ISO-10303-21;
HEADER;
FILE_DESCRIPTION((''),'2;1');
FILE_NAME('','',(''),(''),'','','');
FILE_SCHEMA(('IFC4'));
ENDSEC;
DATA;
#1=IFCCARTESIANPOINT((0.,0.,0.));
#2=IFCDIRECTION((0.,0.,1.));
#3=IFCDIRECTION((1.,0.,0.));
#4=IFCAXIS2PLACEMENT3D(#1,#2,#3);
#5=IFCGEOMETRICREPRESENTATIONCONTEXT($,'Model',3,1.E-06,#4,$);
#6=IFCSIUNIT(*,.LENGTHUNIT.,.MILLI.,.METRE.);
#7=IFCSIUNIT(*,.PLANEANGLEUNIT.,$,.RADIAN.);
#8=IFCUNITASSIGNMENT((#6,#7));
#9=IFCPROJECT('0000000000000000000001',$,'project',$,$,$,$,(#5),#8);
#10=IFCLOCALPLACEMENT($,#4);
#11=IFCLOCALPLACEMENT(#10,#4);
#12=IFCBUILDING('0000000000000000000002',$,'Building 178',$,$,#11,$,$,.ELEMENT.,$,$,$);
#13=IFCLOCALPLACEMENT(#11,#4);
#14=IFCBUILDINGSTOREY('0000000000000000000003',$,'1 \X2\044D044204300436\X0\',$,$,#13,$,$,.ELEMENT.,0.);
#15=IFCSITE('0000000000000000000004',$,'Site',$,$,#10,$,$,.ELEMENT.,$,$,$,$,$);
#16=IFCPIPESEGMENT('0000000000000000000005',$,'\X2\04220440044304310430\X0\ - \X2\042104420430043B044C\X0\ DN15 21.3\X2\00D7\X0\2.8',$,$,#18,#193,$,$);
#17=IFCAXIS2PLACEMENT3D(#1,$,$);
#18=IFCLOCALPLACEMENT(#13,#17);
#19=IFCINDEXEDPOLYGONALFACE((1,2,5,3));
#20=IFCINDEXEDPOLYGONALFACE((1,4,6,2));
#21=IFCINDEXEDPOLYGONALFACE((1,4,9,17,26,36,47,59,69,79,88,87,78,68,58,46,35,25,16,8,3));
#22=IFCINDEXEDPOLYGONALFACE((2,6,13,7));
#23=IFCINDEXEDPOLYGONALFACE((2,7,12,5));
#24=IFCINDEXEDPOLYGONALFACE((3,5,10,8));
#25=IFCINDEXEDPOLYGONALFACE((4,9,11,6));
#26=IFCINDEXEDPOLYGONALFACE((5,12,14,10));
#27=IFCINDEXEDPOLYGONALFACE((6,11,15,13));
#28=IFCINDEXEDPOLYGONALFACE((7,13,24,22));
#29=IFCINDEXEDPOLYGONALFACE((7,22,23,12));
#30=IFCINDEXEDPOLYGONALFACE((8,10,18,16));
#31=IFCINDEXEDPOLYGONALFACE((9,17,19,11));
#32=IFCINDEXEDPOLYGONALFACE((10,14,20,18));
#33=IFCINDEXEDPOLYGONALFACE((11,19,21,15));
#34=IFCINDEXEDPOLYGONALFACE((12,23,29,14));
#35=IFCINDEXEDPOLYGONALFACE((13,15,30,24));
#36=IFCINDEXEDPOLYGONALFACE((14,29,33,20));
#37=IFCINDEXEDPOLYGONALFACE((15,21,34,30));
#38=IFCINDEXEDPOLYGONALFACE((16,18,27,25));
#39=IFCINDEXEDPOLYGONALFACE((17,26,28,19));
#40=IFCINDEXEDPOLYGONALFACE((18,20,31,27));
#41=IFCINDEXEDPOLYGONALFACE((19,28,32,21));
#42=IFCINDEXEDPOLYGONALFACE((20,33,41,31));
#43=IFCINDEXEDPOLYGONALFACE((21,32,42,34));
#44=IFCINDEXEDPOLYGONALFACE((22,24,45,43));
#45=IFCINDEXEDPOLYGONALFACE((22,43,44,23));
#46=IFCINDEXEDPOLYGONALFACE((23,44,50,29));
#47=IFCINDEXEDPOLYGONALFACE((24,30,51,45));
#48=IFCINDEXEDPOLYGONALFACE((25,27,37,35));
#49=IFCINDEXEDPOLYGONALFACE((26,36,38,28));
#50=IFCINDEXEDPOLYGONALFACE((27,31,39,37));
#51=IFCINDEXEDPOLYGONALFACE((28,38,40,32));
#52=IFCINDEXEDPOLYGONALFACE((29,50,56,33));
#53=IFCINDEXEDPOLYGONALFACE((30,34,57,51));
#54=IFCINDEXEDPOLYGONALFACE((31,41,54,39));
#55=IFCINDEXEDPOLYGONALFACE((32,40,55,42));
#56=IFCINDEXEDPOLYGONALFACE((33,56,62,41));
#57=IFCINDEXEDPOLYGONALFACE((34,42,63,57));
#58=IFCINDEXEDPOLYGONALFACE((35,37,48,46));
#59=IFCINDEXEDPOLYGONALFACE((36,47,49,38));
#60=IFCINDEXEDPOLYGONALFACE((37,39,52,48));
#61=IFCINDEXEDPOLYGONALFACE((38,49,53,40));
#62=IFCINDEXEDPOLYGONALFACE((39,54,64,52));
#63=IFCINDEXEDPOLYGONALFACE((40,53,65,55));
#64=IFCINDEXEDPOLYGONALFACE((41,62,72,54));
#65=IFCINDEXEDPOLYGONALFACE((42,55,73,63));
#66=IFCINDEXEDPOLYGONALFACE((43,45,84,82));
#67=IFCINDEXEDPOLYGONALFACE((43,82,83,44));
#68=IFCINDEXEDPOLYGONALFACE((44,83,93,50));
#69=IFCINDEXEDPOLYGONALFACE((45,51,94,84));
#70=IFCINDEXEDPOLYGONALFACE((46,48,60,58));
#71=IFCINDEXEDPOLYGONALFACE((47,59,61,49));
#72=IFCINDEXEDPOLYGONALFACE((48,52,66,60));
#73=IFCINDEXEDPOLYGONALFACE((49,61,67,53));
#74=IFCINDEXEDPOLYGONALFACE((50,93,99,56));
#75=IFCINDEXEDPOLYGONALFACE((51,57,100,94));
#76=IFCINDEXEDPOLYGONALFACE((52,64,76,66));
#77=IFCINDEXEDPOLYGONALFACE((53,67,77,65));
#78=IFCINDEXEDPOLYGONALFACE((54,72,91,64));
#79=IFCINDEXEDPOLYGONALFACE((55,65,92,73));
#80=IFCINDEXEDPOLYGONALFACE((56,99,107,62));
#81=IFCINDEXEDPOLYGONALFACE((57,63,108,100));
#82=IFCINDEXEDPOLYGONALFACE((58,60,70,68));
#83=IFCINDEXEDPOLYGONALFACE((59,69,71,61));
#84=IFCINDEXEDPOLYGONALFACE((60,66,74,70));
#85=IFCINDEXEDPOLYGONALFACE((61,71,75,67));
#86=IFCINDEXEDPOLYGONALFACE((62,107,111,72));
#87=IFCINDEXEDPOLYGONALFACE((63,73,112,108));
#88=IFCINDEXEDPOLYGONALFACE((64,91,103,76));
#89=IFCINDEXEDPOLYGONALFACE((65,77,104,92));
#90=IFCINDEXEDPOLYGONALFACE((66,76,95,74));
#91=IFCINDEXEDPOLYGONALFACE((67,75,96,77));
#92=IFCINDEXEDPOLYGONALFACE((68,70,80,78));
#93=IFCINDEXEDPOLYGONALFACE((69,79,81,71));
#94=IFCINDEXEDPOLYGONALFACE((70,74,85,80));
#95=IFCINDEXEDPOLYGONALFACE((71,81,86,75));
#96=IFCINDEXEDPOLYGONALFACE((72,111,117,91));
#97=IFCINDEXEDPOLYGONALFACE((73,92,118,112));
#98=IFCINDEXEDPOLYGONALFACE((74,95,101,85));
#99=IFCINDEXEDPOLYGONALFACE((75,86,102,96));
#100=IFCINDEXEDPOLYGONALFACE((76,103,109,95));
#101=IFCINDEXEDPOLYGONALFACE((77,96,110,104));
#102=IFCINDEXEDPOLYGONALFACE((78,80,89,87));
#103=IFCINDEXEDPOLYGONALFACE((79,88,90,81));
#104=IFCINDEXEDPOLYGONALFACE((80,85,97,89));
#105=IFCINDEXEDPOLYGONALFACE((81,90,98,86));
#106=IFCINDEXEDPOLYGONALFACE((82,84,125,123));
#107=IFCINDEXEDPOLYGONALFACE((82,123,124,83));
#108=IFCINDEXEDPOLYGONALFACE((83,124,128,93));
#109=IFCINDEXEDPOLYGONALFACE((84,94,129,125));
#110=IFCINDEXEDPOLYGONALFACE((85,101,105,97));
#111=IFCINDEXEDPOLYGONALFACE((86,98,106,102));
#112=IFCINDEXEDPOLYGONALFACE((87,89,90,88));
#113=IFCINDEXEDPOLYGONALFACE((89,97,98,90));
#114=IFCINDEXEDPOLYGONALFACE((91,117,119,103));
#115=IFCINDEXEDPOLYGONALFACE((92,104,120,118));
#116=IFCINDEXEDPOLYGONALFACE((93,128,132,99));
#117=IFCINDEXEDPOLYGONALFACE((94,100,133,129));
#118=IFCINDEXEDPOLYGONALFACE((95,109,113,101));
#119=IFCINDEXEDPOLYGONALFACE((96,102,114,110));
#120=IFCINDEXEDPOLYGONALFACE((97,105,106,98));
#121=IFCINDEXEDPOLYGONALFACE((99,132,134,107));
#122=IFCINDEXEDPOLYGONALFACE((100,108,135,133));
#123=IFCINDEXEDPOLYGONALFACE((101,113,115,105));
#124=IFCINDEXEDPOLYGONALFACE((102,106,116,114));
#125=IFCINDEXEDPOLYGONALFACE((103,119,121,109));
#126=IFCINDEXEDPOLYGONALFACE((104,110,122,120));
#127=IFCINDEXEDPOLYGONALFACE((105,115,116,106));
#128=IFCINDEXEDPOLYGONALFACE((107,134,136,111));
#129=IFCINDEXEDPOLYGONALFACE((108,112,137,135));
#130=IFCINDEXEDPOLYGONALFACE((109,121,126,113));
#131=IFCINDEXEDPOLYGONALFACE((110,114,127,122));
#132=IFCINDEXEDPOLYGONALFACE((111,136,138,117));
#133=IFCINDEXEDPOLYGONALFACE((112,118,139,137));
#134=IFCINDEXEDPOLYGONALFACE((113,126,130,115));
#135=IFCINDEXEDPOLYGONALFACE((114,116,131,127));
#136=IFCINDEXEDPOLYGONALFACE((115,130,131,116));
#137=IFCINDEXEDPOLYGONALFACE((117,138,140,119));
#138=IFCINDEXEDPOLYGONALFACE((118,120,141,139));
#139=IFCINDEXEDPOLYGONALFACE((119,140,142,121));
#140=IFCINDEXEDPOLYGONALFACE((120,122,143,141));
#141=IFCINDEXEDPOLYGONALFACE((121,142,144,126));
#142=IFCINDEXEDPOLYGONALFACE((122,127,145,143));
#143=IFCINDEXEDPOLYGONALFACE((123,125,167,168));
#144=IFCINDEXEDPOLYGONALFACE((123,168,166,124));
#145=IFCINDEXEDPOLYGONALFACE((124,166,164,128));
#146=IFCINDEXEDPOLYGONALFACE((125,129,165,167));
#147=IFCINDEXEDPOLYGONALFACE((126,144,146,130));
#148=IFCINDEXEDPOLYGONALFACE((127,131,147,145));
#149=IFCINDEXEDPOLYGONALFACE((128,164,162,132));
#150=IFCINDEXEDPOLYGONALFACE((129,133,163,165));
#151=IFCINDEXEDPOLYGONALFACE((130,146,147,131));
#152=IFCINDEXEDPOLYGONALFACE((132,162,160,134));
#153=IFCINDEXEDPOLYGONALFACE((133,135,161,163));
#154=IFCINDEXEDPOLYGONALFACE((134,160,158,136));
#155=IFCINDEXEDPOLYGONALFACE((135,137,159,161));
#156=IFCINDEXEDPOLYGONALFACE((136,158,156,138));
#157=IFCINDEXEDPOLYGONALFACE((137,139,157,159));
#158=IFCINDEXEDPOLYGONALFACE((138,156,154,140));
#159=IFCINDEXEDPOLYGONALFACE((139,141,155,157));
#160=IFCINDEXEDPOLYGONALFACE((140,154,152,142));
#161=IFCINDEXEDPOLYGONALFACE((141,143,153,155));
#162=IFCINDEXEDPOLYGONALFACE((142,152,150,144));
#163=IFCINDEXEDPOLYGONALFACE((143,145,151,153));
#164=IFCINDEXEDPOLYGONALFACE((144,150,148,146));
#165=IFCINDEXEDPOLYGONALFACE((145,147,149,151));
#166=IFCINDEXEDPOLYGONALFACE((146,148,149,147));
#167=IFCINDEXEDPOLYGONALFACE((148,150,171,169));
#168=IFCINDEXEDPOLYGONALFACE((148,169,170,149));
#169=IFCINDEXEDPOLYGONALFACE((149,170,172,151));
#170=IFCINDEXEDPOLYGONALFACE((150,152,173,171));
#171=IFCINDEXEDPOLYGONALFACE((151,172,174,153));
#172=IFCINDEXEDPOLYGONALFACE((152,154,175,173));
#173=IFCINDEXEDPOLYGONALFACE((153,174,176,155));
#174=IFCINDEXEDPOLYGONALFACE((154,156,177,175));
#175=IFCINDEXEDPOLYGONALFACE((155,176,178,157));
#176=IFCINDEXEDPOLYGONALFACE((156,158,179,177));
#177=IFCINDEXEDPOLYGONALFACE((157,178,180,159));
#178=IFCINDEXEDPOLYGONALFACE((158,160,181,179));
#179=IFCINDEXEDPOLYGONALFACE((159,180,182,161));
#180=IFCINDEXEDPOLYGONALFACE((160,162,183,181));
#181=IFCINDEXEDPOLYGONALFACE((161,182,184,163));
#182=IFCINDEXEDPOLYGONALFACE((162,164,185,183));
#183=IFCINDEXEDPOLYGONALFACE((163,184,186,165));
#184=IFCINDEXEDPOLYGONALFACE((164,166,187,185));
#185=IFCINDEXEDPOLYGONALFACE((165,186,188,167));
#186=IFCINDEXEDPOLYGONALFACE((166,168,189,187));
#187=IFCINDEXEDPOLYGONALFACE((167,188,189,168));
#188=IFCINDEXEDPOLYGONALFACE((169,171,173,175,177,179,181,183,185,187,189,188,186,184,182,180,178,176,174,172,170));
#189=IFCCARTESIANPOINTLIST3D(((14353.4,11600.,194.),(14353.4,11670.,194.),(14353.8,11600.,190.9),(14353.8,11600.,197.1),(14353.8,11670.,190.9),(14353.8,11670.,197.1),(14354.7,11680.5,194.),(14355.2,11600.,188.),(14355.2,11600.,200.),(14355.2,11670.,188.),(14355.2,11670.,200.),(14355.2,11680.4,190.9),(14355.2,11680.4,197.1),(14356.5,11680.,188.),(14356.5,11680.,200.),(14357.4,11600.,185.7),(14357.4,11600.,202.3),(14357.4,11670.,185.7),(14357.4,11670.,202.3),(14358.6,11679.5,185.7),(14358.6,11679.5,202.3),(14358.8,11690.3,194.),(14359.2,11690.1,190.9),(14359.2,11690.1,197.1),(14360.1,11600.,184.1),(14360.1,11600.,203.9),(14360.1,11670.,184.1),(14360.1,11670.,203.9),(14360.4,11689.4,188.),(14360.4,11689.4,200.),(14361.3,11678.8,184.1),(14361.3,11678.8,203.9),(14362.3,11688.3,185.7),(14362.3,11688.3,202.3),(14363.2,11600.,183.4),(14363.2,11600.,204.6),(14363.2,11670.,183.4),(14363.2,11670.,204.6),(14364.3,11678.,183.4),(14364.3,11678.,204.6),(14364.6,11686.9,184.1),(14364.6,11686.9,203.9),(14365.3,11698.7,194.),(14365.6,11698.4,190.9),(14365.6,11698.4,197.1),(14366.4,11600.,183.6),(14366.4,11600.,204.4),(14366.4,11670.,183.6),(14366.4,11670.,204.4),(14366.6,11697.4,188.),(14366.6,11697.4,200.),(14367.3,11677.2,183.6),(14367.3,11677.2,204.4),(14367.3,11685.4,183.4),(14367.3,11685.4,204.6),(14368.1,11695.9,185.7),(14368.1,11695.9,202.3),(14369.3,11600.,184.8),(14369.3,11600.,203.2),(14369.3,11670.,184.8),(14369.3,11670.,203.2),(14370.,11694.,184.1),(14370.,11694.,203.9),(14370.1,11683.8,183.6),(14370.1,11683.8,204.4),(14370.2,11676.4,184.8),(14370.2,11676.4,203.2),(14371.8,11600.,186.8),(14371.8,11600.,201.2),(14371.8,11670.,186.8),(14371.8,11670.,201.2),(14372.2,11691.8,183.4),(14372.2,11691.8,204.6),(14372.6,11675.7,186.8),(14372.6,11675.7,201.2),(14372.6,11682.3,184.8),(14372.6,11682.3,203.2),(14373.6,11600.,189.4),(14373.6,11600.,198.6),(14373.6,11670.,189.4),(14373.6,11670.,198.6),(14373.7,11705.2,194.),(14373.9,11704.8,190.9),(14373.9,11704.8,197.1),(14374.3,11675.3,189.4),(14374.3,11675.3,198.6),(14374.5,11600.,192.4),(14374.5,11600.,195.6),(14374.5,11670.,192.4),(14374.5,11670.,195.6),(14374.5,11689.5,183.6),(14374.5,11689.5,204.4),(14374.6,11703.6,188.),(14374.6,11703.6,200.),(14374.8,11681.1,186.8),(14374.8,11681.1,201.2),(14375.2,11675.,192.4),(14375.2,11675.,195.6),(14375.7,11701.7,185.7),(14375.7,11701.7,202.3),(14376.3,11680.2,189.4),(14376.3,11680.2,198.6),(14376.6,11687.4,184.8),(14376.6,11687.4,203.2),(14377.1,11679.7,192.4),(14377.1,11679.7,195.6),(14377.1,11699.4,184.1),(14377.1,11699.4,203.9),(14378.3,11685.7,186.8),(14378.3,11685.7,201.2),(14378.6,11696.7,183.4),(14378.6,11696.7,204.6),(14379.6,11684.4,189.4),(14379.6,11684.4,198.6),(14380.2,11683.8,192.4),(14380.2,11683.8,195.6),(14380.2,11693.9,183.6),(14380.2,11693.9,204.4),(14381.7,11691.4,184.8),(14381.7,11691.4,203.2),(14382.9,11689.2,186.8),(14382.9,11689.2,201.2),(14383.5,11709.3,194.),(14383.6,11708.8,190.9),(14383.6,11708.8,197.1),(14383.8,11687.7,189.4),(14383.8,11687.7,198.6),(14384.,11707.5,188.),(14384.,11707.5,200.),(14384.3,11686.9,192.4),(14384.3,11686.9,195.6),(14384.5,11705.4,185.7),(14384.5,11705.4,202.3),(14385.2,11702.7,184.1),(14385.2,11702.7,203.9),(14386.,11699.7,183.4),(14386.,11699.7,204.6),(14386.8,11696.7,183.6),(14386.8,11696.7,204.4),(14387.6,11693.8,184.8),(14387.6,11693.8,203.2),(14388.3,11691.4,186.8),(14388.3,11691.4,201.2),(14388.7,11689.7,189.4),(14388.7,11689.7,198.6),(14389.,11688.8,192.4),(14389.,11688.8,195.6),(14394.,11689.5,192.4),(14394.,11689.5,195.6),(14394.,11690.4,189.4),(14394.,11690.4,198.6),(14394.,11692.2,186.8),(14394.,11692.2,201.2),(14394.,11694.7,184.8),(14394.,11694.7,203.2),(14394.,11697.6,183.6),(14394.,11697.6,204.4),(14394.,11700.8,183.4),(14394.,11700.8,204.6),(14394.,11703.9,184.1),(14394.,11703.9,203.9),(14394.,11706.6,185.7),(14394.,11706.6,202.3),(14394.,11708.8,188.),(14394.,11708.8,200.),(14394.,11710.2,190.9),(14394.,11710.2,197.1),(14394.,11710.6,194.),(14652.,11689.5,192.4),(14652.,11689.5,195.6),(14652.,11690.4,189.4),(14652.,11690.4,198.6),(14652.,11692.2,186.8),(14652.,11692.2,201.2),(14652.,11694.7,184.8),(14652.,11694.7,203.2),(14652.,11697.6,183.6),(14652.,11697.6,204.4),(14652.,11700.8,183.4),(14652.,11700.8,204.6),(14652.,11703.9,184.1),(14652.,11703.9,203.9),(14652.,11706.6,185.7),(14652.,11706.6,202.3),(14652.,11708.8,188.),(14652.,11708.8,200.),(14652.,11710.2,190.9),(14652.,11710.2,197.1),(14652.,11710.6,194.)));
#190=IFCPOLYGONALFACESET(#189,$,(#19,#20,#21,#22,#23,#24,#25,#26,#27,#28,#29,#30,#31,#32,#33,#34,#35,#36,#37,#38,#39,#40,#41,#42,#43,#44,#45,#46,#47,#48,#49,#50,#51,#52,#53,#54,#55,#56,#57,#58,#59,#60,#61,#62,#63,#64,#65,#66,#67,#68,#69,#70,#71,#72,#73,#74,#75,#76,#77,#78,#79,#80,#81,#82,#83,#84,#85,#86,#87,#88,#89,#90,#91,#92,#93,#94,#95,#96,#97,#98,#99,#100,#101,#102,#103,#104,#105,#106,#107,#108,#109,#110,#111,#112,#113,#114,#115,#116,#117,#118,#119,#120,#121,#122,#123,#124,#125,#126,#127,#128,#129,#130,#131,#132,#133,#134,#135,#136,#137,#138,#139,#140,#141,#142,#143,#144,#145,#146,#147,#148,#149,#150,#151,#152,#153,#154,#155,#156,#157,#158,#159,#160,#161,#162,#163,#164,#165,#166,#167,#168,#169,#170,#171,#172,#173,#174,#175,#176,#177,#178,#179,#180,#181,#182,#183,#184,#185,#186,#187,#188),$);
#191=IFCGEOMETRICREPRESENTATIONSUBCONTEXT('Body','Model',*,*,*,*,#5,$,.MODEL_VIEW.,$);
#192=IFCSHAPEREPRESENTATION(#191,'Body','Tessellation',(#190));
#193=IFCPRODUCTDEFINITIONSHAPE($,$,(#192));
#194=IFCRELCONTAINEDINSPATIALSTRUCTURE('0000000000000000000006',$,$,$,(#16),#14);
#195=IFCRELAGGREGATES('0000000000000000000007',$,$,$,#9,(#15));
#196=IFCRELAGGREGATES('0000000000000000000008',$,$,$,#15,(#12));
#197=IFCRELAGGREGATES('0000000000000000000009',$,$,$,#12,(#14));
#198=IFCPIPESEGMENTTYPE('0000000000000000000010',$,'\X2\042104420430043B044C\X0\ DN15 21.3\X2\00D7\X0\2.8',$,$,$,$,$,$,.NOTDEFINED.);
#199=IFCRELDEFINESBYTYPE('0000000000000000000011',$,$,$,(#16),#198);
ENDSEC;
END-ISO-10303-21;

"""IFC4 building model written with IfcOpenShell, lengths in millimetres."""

from ifc_helpers import new_model, entity, si_unit, frame, origin_with_axes, place, context, subcontext, project, spatial, source, transform, mapped, type_object, element, save


model = new_model("IFC4")

# Units and contexts
model_context = context("Model", 3, precision=1e-06, world=origin_with_axes())
body_context = subcontext(model_context, "Body", "Model", "MODEL_VIEW")
ifc_project = project(units=[si_unit("LENGTHUNIT", "METRE", prefix="MILLI"), si_unit("PLANEANGLEUNIT", "RADIAN")], contexts=[model_context])

# Site, building, storey
site_placement = place(None, origin_with_axes())
site = spatial("IfcSite", under=ifc_project, at=site_placement, Name="Site", CompositionType="ELEMENT")
building_placement = place(site_placement, origin_with_axes())
building = spatial("IfcBuilding", under=site, at=building_placement, Name="Building 178", CompositionType="ELEMENT")
storey_placement = place(building_placement, origin_with_axes())
storey = spatial("IfcBuildingStorey", under=building, at=storey_placement, Name="1 этаж", CompositionType="ELEMENT", Elevation=0.0)

# Pipe segment
pipe_segment_type = type_object("IfcPipeSegmentType", Name="Сталь DN15 21.3×2.8", PredefinedType="NOTDEFINED")
shared_shape_1 = source(origin_with_axes(), body_context, "Body", "AdvancedSweptSolid", [
    entity("IfcSweptDiskSolid", entity("IfcIndexedPolyCurve", entity("IfcCartesianPointList3D", [[0.0, 0.0, 0.0], [0.0, 0.0, -70.0], [8.8, 0.0, -91.2], [30.0, 0.0, -100.0], [288.0, 0.0, -100.0]]), [entity("IfcLineIndex", [1, 2]), entity("IfcArcIndex", [2, 3, 4]), entity("IfcLineIndex", [4, 5])]), 10.7),
])
for number, where, z_axis, x_axis, name in (
    (1, (14364.0, 11600.0, 194.0), (0.0, -1.0, 0.0), (1.0, 0.0, 0.0), "Труба - Сталь DN15 21.3×2.8"),
):
    element("IfcPipeSegment", number, at=place(storey_placement, frame(where, z_axis=z_axis, x_axis=x_axis)), inside=storey, type_object=pipe_segment_type, Name=name, context=body_context, shape_type="MappedRepresentation", body=[
        mapped(shared_shape_1, transform((0.0, 0.0, 0.0), x_axis=(1.0, 0.0, 0.0), y_axis=(0.0, 1.0, 0.0), z_axis=(0.0, 0.0, 1.0), scale=1.0)),
    ])

save(model, "model.ifc")
